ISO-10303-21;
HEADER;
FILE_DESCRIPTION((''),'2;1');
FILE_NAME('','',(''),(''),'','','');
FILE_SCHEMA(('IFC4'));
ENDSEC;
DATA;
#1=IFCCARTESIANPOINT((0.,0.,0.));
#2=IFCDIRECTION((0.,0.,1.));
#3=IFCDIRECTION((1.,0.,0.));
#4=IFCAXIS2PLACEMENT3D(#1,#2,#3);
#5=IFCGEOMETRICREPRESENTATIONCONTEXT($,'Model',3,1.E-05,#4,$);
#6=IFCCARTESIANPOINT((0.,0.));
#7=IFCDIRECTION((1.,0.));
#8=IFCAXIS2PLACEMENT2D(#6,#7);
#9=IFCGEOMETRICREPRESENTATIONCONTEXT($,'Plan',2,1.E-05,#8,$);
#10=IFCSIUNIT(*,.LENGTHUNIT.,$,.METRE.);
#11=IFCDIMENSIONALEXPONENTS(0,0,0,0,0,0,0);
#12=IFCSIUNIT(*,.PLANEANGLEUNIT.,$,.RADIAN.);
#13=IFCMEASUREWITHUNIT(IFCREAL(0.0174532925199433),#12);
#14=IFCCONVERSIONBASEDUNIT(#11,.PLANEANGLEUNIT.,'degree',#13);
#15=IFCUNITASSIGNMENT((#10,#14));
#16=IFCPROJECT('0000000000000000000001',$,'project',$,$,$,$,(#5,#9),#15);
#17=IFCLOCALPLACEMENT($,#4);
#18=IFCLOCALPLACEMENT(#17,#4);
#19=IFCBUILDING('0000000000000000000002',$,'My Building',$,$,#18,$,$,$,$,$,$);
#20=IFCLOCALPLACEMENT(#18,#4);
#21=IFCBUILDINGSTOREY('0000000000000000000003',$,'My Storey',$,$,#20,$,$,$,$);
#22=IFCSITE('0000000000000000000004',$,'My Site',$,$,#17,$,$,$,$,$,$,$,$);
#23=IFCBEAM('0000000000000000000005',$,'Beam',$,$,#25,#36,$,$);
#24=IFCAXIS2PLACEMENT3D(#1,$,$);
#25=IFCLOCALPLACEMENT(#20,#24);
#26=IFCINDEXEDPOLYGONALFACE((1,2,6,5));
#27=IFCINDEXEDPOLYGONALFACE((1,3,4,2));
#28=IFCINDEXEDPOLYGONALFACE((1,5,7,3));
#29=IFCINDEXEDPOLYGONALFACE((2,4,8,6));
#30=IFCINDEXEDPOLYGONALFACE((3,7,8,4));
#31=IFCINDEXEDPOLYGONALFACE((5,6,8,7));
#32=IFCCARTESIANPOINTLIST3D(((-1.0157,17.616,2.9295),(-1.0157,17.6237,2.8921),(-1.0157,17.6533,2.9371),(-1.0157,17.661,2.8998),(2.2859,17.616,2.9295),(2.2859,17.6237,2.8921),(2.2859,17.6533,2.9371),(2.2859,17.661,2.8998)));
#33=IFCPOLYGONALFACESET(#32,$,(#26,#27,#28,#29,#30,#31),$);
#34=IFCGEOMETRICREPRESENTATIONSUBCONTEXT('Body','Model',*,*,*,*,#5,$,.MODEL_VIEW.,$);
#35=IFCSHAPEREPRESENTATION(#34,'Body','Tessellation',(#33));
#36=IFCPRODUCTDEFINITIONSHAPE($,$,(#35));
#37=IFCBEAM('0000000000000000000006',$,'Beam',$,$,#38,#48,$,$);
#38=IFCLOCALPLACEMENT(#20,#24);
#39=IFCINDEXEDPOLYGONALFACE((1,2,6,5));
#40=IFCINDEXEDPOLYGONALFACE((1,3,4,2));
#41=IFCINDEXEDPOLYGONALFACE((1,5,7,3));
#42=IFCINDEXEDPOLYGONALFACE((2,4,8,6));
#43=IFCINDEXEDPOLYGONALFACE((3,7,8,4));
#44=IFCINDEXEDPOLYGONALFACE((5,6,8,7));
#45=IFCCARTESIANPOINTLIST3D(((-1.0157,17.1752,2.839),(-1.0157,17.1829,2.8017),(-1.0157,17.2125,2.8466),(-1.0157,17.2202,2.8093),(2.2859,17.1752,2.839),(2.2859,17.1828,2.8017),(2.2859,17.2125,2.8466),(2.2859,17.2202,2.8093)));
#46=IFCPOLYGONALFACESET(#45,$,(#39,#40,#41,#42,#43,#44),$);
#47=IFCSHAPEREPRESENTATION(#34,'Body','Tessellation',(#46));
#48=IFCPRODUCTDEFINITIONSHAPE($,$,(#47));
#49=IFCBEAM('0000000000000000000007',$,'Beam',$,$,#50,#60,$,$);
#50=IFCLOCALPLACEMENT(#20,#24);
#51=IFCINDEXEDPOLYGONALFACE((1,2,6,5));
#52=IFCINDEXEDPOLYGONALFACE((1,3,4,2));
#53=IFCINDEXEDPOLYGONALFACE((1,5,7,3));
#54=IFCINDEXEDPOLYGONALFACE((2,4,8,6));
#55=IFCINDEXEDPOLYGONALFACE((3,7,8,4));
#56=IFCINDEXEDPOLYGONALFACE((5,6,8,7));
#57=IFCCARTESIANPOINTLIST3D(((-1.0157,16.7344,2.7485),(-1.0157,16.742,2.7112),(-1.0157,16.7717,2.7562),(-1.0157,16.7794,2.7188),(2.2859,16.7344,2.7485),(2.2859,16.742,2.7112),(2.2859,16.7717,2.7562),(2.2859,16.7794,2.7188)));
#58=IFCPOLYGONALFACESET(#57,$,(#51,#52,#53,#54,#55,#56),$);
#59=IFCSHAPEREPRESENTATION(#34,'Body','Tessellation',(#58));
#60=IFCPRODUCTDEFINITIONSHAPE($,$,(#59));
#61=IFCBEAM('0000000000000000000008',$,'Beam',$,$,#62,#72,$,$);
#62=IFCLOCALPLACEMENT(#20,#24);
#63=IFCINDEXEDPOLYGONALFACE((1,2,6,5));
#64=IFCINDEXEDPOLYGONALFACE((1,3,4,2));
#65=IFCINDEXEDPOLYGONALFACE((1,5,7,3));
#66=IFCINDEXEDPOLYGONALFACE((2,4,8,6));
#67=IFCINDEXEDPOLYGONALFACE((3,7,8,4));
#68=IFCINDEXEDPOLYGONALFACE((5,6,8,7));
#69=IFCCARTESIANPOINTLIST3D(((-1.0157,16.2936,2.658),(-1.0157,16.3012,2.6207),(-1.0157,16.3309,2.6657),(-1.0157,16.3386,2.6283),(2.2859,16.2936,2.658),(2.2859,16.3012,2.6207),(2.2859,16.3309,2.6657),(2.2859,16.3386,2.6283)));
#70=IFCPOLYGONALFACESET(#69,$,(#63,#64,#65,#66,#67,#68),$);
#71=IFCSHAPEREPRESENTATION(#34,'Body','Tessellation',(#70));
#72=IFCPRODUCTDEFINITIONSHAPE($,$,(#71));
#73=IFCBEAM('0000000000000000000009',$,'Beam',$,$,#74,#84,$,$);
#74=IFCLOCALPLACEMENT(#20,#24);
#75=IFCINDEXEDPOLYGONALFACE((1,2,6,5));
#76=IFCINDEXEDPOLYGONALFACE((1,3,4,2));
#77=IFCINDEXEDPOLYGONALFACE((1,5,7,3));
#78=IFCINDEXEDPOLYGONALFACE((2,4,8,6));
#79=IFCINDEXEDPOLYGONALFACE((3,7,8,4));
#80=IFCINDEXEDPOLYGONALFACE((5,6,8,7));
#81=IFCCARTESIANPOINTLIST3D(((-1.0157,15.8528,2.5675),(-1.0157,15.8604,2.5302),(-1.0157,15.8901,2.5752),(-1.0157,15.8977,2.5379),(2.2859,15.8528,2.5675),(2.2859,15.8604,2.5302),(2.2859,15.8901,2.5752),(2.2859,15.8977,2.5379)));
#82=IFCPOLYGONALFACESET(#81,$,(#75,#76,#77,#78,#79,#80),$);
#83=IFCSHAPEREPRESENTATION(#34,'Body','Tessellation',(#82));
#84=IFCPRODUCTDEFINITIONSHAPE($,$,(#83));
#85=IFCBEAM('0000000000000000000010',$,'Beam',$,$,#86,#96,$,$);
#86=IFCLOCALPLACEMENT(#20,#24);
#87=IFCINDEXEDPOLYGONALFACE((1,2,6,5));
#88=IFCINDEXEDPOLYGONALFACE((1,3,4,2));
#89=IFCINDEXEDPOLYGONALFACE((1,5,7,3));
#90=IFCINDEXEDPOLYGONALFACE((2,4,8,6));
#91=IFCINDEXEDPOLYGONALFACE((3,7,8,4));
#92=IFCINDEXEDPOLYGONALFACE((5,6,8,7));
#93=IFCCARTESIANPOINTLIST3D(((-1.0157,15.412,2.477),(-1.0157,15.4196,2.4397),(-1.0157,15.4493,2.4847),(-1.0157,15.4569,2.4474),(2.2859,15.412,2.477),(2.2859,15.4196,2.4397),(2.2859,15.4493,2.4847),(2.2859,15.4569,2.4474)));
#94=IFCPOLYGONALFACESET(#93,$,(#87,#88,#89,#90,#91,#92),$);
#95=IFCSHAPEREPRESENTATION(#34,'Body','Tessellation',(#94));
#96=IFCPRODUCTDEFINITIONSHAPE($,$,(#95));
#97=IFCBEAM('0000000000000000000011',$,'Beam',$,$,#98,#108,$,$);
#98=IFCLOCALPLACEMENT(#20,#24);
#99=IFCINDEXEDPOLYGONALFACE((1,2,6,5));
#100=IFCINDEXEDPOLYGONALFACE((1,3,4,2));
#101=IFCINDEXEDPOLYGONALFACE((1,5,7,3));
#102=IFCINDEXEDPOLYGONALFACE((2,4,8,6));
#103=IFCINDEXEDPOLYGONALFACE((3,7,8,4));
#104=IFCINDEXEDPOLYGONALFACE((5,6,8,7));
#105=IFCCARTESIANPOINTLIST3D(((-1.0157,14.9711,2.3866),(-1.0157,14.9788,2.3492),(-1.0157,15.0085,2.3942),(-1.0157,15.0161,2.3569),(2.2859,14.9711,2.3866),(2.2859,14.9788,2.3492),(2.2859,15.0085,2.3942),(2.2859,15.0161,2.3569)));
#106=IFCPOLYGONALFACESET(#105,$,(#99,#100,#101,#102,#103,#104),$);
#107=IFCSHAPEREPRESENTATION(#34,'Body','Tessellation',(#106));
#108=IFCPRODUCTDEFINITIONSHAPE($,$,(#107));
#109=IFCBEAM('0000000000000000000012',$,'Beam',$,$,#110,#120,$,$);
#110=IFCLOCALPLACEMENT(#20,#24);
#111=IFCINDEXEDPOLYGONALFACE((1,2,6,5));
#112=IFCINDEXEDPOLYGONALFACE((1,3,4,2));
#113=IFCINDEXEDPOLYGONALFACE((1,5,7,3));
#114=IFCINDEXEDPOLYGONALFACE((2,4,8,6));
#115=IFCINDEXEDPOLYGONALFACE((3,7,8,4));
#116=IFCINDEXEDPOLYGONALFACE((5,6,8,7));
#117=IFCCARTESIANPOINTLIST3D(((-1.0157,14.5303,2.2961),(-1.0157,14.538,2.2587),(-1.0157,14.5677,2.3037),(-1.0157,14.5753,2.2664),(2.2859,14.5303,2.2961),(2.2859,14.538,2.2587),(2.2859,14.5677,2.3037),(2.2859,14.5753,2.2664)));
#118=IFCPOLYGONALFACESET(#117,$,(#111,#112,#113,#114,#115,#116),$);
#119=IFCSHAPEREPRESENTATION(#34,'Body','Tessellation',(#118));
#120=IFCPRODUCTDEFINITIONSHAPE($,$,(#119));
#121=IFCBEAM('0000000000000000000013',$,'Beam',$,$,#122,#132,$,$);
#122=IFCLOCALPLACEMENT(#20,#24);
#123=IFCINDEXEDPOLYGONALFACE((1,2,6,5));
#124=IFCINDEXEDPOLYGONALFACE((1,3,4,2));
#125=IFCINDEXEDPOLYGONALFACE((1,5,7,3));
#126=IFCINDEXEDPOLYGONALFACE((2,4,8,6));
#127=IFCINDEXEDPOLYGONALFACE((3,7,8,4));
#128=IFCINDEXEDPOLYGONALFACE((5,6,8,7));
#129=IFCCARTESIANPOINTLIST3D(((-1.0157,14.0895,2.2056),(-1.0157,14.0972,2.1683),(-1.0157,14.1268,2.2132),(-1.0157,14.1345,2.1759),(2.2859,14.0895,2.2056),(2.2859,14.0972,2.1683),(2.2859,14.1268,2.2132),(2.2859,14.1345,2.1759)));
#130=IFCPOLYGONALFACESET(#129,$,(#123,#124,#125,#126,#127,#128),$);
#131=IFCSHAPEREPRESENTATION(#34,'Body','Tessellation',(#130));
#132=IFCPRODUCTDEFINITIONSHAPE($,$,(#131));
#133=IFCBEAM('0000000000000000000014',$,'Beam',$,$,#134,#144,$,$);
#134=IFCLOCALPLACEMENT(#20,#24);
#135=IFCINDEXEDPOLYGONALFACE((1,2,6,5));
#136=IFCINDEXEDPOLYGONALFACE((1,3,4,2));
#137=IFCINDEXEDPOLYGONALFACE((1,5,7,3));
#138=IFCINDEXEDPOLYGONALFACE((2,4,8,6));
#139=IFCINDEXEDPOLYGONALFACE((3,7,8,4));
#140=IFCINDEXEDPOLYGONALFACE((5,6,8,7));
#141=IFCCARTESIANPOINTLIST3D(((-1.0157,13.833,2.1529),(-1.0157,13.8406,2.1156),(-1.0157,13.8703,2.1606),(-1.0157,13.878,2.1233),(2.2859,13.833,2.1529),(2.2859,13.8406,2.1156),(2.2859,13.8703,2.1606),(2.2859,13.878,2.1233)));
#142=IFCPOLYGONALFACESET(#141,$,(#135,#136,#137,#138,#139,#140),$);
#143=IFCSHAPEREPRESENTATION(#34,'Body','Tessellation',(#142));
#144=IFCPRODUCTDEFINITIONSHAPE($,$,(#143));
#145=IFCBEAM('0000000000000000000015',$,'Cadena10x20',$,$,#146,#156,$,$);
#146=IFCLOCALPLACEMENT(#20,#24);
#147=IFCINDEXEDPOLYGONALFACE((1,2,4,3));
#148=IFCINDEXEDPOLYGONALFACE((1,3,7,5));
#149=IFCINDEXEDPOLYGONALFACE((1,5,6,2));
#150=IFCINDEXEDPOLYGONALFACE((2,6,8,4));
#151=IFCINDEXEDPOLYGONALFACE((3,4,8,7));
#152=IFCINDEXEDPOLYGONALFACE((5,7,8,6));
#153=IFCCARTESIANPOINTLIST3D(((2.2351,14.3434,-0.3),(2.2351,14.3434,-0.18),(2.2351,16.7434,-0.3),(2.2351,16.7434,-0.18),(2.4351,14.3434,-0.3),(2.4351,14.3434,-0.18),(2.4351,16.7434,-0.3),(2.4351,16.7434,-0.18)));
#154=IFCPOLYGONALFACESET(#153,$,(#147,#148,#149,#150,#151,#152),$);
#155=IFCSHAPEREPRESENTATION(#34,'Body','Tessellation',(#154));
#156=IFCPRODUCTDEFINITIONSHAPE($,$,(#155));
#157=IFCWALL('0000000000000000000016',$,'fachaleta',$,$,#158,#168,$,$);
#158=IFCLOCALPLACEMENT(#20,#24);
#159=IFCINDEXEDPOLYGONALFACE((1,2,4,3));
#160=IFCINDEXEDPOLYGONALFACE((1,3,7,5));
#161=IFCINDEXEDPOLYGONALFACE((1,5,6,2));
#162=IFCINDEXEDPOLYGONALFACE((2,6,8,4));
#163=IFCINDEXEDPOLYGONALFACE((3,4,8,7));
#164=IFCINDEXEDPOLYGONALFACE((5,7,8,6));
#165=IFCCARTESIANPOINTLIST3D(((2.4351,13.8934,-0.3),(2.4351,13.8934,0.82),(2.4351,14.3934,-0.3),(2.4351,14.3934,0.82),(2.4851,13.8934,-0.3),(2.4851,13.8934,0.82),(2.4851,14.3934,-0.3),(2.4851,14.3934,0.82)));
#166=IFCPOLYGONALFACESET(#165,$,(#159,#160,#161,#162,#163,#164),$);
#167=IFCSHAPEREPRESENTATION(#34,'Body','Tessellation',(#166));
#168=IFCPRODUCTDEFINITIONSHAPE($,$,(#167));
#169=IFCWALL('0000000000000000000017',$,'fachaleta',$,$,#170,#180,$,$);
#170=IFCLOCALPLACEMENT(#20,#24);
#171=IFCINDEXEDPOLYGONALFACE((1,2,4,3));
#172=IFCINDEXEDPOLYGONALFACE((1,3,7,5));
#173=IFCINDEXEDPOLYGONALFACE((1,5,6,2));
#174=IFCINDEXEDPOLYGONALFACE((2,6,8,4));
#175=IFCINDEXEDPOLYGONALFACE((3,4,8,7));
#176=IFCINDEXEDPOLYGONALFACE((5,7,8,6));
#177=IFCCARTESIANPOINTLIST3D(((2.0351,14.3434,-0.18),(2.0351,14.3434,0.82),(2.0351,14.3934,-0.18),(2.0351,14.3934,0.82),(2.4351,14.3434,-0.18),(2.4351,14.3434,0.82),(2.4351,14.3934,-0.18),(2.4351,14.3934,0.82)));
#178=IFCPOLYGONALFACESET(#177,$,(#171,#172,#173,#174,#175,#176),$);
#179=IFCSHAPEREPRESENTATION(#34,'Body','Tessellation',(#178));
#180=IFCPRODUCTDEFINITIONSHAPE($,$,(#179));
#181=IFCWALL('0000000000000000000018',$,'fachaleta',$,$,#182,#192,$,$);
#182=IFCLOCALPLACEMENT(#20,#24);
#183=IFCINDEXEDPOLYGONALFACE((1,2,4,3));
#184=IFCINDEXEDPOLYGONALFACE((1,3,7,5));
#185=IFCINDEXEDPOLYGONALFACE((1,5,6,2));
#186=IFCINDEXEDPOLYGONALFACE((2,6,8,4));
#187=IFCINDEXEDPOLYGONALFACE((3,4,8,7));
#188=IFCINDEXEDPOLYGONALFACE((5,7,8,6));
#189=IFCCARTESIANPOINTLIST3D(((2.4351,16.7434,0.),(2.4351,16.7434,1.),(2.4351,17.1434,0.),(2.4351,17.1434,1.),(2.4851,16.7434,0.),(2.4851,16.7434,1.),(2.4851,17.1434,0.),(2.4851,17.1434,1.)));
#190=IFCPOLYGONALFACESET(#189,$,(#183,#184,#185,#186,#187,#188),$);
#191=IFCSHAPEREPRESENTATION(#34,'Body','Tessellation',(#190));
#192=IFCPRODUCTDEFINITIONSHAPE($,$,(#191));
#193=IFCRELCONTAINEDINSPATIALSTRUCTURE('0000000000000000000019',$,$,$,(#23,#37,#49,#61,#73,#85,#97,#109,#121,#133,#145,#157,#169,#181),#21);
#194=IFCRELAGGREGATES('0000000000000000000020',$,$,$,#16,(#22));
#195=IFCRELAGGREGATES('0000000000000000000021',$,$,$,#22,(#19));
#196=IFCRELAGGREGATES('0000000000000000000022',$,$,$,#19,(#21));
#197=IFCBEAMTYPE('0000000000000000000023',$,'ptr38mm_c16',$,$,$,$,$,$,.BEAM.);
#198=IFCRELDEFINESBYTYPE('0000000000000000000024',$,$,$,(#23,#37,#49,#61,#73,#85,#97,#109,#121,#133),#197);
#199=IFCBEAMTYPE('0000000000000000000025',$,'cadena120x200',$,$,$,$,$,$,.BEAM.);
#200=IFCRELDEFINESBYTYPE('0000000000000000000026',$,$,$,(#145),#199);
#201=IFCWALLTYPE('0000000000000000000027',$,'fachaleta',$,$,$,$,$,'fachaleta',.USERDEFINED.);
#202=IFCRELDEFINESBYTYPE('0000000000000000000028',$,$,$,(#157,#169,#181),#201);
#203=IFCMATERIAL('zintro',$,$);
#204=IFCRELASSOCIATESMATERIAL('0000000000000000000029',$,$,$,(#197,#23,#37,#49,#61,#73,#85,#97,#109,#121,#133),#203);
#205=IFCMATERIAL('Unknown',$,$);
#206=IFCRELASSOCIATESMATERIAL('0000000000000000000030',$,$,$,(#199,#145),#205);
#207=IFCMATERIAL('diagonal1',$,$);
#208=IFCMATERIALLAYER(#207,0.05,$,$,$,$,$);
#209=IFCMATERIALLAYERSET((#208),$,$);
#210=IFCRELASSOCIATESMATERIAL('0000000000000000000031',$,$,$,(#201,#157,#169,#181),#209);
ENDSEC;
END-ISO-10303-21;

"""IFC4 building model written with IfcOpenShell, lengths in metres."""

from ifc_helpers import new_model, entity, si_unit, converted_unit, frame, origin_with_axes, origin_2d_with_axis, place, context, subcontext, project, spatial, indexed_curve, rectangle, outline, extrude, material, layer, layer_set, layer_usage, material_profile, profile_set, profile_usage, type_object, element, save


model = new_model("IFC4")

# Units and contexts
model_context = context("Model", 3, precision=1e-05, world=origin_with_axes())
plan_context = context("Plan", 2, precision=1e-05, world=origin_2d_with_axis())
body_context = subcontext(model_context, "Body", "Model", "MODEL_VIEW")
ifc_project = project(units=[si_unit("LENGTHUNIT", "METRE"), converted_unit("PLANEANGLEUNIT", "degree", entity("IfcReal", 0.0174532925199433), si_unit("PLANEANGLEUNIT", "RADIAN"), dimensions=[0, 0, 0, 0, 0, 0, 0])], contexts=[model_context, plan_context])

# Site, building, storey
site_placement = place(None, origin_with_axes())
site = spatial("IfcSite", under=ifc_project, at=site_placement, Name="My Site")
building_placement = place(site_placement, origin_with_axes())
building = spatial("IfcBuilding", under=site, at=building_placement, Name="My Building")
storey_placement = place(building_placement, origin_with_axes())
storey = spatial("IfcBuildingStorey", under=building, at=storey_placement, Name="My Storey")

# Beams
ifc_material_1 = material(Name="zintro")
ifc_material_profile_1 = material_profile(ifc_material_1, rectangle(XDim=0.0381, YDim=0.0381))
ifc_profile_set_1 = profile_set([ifc_material_profile_1])
beam_type_1 = type_object("IfcBeamType", Name="ptr38mm_c16", PredefinedType="BEAM", material=ifc_profile_set_1)
ifc_profile_usage_1 = profile_usage(ifc_profile_set_1)
beam_1_placement = place(storey_placement, frame((2.2859, 17.6385, 2.9146), z_axis=(-1.0, 0.0, 0.0), x_axis=(0.0, -0.979575, -0.201078)))
element("IfcBeam", 1, at=beam_1_placement, inside=storey, type_object=beam_type_1, material=ifc_profile_usage_1, Name="Beam", context=body_context, shape_type="SweptSolid", body=[
    extrude(rectangle(XDim=0.0381, YDim=0.0381), origin_with_axes(), (0.0, 0.0, 1.0), 3.3016),
])
ifc_profile_usage_2 = profile_usage(ifc_profile_set_1)
beam_2_placement = place(storey_placement, frame((2.2859, 17.1977, 2.8241), z_axis=(-1.0, 0.0, 0.0), x_axis=(0.0, -0.979575, -0.201078)))
element("IfcBeam", 2, at=beam_2_placement, inside=storey, type_object=beam_type_1, material=ifc_profile_usage_2, Name="Beam", context=body_context, shape_type="SweptSolid", body=[
    extrude(rectangle(XDim=0.0381, YDim=0.0381), origin_with_axes(), (0.0, 0.0, 1.0), 3.3016),
])
ifc_profile_usage_3 = profile_usage(ifc_profile_set_1)
beam_3_placement = place(storey_placement, frame((2.2859, 16.7569, 2.7337), z_axis=(-1.0, 0.0, 0.0), x_axis=(0.0, -0.979575, -0.201078)))
element("IfcBeam", 3, at=beam_3_placement, inside=storey, type_object=beam_type_1, material=ifc_profile_usage_3, Name="Beam", context=body_context, shape_type="SweptSolid", body=[
    extrude(rectangle(XDim=0.0381, YDim=0.0381), origin_with_axes(), (0.0, 0.0, 1.0), 3.3016),
])
ifc_profile_usage_4 = profile_usage(ifc_profile_set_1)
beam_4_placement = place(storey_placement, frame((2.2859, 16.3161, 2.6432), z_axis=(-1.0, 0.0, 0.0), x_axis=(0.0, -0.979575, -0.201078)))
element("IfcBeam", 4, at=beam_4_placement, inside=storey, type_object=beam_type_1, material=ifc_profile_usage_4, Name="Beam", context=body_context, shape_type="SweptSolid", body=[
    extrude(rectangle(XDim=0.0381, YDim=0.0381), origin_with_axes(), (0.0, 0.0, 1.0), 3.3016),
])
ifc_profile_usage_5 = profile_usage(ifc_profile_set_1)
beam_5_placement = place(storey_placement, frame((2.2859, 15.8753, 2.5527), z_axis=(-1.0, 0.0, 0.0), x_axis=(0.0, -0.979575, -0.201078)))
element("IfcBeam", 5, at=beam_5_placement, inside=storey, type_object=beam_type_1, material=ifc_profile_usage_5, Name="Beam", context=body_context, shape_type="SweptSolid", body=[
    extrude(rectangle(XDim=0.0381, YDim=0.0381), origin_with_axes(), (0.0, 0.0, 1.0), 3.3016),
])
ifc_profile_usage_6 = profile_usage(ifc_profile_set_1)
beam_6_placement = place(storey_placement, frame((2.2859, 15.4344, 2.4622), z_axis=(-1.0, 0.0, 0.0), x_axis=(0.0, -0.979575, -0.201078)))
element("IfcBeam", 6, at=beam_6_placement, inside=storey, type_object=beam_type_1, material=ifc_profile_usage_6, Name="Beam", context=body_context, shape_type="SweptSolid", body=[
    extrude(rectangle(XDim=0.0381, YDim=0.0381), origin_with_axes(), (0.0, 0.0, 1.0), 3.3016),
])
ifc_profile_usage_7 = profile_usage(ifc_profile_set_1)
beam_7_placement = place(storey_placement, frame((2.2859, 14.9936, 2.3717), z_axis=(-1.0, 0.0, 0.0), x_axis=(0.0, -0.979575, -0.201078)))
element("IfcBeam", 7, at=beam_7_placement, inside=storey, type_object=beam_type_1, material=ifc_profile_usage_7, Name="Beam", context=body_context, shape_type="SweptSolid", body=[
    extrude(rectangle(XDim=0.0381, YDim=0.0381), origin_with_axes(), (0.0, 0.0, 1.0), 3.3016),
])
ifc_profile_usage_8 = profile_usage(ifc_profile_set_1)
beam_8_placement = place(storey_placement, frame((2.2859, 14.5528, 2.2812), z_axis=(-1.0, 0.0, 0.0), x_axis=(0.0, -0.979575, -0.201078)))
element("IfcBeam", 8, at=beam_8_placement, inside=storey, type_object=beam_type_1, material=ifc_profile_usage_8, Name="Beam", context=body_context, shape_type="SweptSolid", body=[
    extrude(rectangle(XDim=0.0381, YDim=0.0381), origin_with_axes(), (0.0, 0.0, 1.0), 3.3016),
])
ifc_profile_usage_9 = profile_usage(ifc_profile_set_1)
beam_9_placement = place(storey_placement, frame((2.2859, 14.112, 2.1908), z_axis=(-1.0, 0.0, 0.0), x_axis=(0.0, -0.979575, -0.201078)))
element("IfcBeam", 9, at=beam_9_placement, inside=storey, type_object=beam_type_1, material=ifc_profile_usage_9, Name="Beam", context=body_context, shape_type="SweptSolid", body=[
    extrude(rectangle(XDim=0.0381, YDim=0.0381), origin_with_axes(), (0.0, 0.0, 1.0), 3.3016),
])
ifc_profile_usage_10 = profile_usage(ifc_profile_set_1)
beam_10_placement = place(storey_placement, frame((2.2859, 13.8555, 2.1381), z_axis=(-1.0, 0.0, 0.0), x_axis=(0.0, -0.979575, -0.201078)))
element("IfcBeam", 10, at=beam_10_placement, inside=storey, type_object=beam_type_1, material=ifc_profile_usage_10, Name="Beam", context=body_context, shape_type="SweptSolid", body=[
    extrude(rectangle(XDim=0.0381, YDim=0.0381), origin_with_axes(), (0.0, 0.0, 1.0), 3.3016),
])
ifc_material_2 = material(Name="Unknown")
ifc_material_profile_2 = material_profile(ifc_material_2, rectangle(XDim=0.2, YDim=0.12))
ifc_profile_set_2 = profile_set([ifc_material_profile_2], Name="concrete")
ifc_profile_usage_11 = profile_usage(ifc_profile_set_2, cardinal=5)
beam_type_2 = type_object("IfcBeamType", Name="cadena120x200", PredefinedType="BEAM", material=ifc_profile_set_2)
beam_11_placement = place(storey_placement, frame((2.3351, 16.7434, -0.24), z_axis=(0.0, -1.0, 0.0), x_axis=(1.0, 0.0, 0.0)))
element("IfcBeam", 11, at=beam_11_placement, inside=storey, type_object=beam_type_2, material=ifc_profile_usage_11, Name="Cadena10x20", context=body_context, shape_type="SweptSolid", body=[
    extrude(rectangle(XDim=0.2, YDim=0.12), origin_with_axes(), (0.0, 0.0, 1.0), 2.4),
])

# Walls
ifc_material_3 = material(Name="diagonal1")
ifc_layer = layer(ifc_material_3, 0.05)
ifc_layer_set = layer_set([ifc_layer])
ifc_layer_usage_1 = layer_usage(ifc_layer_set, "AXIS2", "POSITIVE", 0.0)
wall_type = type_object("IfcWallType", Name="fachaleta", ElementType="fachaleta", PredefinedType="USERDEFINED", material=ifc_layer_set)
wall_1_placement = place(storey_placement, frame((2.4851, 13.8934, -0.3), z_axis=(0.0, 0.0, 1.0), x_axis=(0.0, 1.0, 0.0)))
element("IfcWall", 12, at=wall_1_placement, inside=storey, type_object=wall_type, material=ifc_layer_usage_1, Name="fachaleta", context=body_context, shape_type="SweptSolid", body=[
    extrude(outline(indexed_curve([(0.0, 0.0), (0.0, 0.05), (0.5, 0.05), (0.5, 0.0), (0.0, 0.0)], self_intersect=False)), origin_with_axes(), (0.0, 0.0, 1.0), 1.12),
])
ifc_layer_usage_2 = layer_usage(ifc_layer_set, "AXIS2", "POSITIVE", 0.0)
wall_2_placement = place(storey_placement, frame((2.4351, 14.3934, -0.18), z_axis=(0.0, 0.0, 1.0), x_axis=(-1.0, 0.0, 0.0)))
element("IfcWall", 13, at=wall_2_placement, inside=storey, type_object=wall_type, material=ifc_layer_usage_2, Name="fachaleta", context=body_context, shape_type="SweptSolid", body=[
    extrude(outline(indexed_curve([(0.0, 0.0), (0.0, 0.05), (0.4, 0.05), (0.4, 0.0), (0.0, 0.0)], self_intersect=False)), origin_with_axes(), (0.0, 0.0, 1.0), 1.0),
])
ifc_layer_usage_3 = layer_usage(ifc_layer_set, "AXIS2", "POSITIVE", 0.0)
wall_3_placement = place(storey_placement, frame((2.4851, 16.7434, 0.0), z_axis=(0.0, 0.0, 1.0), x_axis=(0.0, 1.0, 0.0)))
element("IfcWall", 14, at=wall_3_placement, inside=storey, type_object=wall_type, material=ifc_layer_usage_3, Name="fachaleta", context=body_context, shape_type="SweptSolid", body=[
    extrude(outline(indexed_curve([(0.0, 0.0), (0.0, 0.05), (0.4, 0.05), (0.4, 0.0), (0.0, 0.0)], self_intersect=False)), origin_with_axes(), (0.0, 0.0, 1.0), 1.0),
])

save(model, "model.ifc")
